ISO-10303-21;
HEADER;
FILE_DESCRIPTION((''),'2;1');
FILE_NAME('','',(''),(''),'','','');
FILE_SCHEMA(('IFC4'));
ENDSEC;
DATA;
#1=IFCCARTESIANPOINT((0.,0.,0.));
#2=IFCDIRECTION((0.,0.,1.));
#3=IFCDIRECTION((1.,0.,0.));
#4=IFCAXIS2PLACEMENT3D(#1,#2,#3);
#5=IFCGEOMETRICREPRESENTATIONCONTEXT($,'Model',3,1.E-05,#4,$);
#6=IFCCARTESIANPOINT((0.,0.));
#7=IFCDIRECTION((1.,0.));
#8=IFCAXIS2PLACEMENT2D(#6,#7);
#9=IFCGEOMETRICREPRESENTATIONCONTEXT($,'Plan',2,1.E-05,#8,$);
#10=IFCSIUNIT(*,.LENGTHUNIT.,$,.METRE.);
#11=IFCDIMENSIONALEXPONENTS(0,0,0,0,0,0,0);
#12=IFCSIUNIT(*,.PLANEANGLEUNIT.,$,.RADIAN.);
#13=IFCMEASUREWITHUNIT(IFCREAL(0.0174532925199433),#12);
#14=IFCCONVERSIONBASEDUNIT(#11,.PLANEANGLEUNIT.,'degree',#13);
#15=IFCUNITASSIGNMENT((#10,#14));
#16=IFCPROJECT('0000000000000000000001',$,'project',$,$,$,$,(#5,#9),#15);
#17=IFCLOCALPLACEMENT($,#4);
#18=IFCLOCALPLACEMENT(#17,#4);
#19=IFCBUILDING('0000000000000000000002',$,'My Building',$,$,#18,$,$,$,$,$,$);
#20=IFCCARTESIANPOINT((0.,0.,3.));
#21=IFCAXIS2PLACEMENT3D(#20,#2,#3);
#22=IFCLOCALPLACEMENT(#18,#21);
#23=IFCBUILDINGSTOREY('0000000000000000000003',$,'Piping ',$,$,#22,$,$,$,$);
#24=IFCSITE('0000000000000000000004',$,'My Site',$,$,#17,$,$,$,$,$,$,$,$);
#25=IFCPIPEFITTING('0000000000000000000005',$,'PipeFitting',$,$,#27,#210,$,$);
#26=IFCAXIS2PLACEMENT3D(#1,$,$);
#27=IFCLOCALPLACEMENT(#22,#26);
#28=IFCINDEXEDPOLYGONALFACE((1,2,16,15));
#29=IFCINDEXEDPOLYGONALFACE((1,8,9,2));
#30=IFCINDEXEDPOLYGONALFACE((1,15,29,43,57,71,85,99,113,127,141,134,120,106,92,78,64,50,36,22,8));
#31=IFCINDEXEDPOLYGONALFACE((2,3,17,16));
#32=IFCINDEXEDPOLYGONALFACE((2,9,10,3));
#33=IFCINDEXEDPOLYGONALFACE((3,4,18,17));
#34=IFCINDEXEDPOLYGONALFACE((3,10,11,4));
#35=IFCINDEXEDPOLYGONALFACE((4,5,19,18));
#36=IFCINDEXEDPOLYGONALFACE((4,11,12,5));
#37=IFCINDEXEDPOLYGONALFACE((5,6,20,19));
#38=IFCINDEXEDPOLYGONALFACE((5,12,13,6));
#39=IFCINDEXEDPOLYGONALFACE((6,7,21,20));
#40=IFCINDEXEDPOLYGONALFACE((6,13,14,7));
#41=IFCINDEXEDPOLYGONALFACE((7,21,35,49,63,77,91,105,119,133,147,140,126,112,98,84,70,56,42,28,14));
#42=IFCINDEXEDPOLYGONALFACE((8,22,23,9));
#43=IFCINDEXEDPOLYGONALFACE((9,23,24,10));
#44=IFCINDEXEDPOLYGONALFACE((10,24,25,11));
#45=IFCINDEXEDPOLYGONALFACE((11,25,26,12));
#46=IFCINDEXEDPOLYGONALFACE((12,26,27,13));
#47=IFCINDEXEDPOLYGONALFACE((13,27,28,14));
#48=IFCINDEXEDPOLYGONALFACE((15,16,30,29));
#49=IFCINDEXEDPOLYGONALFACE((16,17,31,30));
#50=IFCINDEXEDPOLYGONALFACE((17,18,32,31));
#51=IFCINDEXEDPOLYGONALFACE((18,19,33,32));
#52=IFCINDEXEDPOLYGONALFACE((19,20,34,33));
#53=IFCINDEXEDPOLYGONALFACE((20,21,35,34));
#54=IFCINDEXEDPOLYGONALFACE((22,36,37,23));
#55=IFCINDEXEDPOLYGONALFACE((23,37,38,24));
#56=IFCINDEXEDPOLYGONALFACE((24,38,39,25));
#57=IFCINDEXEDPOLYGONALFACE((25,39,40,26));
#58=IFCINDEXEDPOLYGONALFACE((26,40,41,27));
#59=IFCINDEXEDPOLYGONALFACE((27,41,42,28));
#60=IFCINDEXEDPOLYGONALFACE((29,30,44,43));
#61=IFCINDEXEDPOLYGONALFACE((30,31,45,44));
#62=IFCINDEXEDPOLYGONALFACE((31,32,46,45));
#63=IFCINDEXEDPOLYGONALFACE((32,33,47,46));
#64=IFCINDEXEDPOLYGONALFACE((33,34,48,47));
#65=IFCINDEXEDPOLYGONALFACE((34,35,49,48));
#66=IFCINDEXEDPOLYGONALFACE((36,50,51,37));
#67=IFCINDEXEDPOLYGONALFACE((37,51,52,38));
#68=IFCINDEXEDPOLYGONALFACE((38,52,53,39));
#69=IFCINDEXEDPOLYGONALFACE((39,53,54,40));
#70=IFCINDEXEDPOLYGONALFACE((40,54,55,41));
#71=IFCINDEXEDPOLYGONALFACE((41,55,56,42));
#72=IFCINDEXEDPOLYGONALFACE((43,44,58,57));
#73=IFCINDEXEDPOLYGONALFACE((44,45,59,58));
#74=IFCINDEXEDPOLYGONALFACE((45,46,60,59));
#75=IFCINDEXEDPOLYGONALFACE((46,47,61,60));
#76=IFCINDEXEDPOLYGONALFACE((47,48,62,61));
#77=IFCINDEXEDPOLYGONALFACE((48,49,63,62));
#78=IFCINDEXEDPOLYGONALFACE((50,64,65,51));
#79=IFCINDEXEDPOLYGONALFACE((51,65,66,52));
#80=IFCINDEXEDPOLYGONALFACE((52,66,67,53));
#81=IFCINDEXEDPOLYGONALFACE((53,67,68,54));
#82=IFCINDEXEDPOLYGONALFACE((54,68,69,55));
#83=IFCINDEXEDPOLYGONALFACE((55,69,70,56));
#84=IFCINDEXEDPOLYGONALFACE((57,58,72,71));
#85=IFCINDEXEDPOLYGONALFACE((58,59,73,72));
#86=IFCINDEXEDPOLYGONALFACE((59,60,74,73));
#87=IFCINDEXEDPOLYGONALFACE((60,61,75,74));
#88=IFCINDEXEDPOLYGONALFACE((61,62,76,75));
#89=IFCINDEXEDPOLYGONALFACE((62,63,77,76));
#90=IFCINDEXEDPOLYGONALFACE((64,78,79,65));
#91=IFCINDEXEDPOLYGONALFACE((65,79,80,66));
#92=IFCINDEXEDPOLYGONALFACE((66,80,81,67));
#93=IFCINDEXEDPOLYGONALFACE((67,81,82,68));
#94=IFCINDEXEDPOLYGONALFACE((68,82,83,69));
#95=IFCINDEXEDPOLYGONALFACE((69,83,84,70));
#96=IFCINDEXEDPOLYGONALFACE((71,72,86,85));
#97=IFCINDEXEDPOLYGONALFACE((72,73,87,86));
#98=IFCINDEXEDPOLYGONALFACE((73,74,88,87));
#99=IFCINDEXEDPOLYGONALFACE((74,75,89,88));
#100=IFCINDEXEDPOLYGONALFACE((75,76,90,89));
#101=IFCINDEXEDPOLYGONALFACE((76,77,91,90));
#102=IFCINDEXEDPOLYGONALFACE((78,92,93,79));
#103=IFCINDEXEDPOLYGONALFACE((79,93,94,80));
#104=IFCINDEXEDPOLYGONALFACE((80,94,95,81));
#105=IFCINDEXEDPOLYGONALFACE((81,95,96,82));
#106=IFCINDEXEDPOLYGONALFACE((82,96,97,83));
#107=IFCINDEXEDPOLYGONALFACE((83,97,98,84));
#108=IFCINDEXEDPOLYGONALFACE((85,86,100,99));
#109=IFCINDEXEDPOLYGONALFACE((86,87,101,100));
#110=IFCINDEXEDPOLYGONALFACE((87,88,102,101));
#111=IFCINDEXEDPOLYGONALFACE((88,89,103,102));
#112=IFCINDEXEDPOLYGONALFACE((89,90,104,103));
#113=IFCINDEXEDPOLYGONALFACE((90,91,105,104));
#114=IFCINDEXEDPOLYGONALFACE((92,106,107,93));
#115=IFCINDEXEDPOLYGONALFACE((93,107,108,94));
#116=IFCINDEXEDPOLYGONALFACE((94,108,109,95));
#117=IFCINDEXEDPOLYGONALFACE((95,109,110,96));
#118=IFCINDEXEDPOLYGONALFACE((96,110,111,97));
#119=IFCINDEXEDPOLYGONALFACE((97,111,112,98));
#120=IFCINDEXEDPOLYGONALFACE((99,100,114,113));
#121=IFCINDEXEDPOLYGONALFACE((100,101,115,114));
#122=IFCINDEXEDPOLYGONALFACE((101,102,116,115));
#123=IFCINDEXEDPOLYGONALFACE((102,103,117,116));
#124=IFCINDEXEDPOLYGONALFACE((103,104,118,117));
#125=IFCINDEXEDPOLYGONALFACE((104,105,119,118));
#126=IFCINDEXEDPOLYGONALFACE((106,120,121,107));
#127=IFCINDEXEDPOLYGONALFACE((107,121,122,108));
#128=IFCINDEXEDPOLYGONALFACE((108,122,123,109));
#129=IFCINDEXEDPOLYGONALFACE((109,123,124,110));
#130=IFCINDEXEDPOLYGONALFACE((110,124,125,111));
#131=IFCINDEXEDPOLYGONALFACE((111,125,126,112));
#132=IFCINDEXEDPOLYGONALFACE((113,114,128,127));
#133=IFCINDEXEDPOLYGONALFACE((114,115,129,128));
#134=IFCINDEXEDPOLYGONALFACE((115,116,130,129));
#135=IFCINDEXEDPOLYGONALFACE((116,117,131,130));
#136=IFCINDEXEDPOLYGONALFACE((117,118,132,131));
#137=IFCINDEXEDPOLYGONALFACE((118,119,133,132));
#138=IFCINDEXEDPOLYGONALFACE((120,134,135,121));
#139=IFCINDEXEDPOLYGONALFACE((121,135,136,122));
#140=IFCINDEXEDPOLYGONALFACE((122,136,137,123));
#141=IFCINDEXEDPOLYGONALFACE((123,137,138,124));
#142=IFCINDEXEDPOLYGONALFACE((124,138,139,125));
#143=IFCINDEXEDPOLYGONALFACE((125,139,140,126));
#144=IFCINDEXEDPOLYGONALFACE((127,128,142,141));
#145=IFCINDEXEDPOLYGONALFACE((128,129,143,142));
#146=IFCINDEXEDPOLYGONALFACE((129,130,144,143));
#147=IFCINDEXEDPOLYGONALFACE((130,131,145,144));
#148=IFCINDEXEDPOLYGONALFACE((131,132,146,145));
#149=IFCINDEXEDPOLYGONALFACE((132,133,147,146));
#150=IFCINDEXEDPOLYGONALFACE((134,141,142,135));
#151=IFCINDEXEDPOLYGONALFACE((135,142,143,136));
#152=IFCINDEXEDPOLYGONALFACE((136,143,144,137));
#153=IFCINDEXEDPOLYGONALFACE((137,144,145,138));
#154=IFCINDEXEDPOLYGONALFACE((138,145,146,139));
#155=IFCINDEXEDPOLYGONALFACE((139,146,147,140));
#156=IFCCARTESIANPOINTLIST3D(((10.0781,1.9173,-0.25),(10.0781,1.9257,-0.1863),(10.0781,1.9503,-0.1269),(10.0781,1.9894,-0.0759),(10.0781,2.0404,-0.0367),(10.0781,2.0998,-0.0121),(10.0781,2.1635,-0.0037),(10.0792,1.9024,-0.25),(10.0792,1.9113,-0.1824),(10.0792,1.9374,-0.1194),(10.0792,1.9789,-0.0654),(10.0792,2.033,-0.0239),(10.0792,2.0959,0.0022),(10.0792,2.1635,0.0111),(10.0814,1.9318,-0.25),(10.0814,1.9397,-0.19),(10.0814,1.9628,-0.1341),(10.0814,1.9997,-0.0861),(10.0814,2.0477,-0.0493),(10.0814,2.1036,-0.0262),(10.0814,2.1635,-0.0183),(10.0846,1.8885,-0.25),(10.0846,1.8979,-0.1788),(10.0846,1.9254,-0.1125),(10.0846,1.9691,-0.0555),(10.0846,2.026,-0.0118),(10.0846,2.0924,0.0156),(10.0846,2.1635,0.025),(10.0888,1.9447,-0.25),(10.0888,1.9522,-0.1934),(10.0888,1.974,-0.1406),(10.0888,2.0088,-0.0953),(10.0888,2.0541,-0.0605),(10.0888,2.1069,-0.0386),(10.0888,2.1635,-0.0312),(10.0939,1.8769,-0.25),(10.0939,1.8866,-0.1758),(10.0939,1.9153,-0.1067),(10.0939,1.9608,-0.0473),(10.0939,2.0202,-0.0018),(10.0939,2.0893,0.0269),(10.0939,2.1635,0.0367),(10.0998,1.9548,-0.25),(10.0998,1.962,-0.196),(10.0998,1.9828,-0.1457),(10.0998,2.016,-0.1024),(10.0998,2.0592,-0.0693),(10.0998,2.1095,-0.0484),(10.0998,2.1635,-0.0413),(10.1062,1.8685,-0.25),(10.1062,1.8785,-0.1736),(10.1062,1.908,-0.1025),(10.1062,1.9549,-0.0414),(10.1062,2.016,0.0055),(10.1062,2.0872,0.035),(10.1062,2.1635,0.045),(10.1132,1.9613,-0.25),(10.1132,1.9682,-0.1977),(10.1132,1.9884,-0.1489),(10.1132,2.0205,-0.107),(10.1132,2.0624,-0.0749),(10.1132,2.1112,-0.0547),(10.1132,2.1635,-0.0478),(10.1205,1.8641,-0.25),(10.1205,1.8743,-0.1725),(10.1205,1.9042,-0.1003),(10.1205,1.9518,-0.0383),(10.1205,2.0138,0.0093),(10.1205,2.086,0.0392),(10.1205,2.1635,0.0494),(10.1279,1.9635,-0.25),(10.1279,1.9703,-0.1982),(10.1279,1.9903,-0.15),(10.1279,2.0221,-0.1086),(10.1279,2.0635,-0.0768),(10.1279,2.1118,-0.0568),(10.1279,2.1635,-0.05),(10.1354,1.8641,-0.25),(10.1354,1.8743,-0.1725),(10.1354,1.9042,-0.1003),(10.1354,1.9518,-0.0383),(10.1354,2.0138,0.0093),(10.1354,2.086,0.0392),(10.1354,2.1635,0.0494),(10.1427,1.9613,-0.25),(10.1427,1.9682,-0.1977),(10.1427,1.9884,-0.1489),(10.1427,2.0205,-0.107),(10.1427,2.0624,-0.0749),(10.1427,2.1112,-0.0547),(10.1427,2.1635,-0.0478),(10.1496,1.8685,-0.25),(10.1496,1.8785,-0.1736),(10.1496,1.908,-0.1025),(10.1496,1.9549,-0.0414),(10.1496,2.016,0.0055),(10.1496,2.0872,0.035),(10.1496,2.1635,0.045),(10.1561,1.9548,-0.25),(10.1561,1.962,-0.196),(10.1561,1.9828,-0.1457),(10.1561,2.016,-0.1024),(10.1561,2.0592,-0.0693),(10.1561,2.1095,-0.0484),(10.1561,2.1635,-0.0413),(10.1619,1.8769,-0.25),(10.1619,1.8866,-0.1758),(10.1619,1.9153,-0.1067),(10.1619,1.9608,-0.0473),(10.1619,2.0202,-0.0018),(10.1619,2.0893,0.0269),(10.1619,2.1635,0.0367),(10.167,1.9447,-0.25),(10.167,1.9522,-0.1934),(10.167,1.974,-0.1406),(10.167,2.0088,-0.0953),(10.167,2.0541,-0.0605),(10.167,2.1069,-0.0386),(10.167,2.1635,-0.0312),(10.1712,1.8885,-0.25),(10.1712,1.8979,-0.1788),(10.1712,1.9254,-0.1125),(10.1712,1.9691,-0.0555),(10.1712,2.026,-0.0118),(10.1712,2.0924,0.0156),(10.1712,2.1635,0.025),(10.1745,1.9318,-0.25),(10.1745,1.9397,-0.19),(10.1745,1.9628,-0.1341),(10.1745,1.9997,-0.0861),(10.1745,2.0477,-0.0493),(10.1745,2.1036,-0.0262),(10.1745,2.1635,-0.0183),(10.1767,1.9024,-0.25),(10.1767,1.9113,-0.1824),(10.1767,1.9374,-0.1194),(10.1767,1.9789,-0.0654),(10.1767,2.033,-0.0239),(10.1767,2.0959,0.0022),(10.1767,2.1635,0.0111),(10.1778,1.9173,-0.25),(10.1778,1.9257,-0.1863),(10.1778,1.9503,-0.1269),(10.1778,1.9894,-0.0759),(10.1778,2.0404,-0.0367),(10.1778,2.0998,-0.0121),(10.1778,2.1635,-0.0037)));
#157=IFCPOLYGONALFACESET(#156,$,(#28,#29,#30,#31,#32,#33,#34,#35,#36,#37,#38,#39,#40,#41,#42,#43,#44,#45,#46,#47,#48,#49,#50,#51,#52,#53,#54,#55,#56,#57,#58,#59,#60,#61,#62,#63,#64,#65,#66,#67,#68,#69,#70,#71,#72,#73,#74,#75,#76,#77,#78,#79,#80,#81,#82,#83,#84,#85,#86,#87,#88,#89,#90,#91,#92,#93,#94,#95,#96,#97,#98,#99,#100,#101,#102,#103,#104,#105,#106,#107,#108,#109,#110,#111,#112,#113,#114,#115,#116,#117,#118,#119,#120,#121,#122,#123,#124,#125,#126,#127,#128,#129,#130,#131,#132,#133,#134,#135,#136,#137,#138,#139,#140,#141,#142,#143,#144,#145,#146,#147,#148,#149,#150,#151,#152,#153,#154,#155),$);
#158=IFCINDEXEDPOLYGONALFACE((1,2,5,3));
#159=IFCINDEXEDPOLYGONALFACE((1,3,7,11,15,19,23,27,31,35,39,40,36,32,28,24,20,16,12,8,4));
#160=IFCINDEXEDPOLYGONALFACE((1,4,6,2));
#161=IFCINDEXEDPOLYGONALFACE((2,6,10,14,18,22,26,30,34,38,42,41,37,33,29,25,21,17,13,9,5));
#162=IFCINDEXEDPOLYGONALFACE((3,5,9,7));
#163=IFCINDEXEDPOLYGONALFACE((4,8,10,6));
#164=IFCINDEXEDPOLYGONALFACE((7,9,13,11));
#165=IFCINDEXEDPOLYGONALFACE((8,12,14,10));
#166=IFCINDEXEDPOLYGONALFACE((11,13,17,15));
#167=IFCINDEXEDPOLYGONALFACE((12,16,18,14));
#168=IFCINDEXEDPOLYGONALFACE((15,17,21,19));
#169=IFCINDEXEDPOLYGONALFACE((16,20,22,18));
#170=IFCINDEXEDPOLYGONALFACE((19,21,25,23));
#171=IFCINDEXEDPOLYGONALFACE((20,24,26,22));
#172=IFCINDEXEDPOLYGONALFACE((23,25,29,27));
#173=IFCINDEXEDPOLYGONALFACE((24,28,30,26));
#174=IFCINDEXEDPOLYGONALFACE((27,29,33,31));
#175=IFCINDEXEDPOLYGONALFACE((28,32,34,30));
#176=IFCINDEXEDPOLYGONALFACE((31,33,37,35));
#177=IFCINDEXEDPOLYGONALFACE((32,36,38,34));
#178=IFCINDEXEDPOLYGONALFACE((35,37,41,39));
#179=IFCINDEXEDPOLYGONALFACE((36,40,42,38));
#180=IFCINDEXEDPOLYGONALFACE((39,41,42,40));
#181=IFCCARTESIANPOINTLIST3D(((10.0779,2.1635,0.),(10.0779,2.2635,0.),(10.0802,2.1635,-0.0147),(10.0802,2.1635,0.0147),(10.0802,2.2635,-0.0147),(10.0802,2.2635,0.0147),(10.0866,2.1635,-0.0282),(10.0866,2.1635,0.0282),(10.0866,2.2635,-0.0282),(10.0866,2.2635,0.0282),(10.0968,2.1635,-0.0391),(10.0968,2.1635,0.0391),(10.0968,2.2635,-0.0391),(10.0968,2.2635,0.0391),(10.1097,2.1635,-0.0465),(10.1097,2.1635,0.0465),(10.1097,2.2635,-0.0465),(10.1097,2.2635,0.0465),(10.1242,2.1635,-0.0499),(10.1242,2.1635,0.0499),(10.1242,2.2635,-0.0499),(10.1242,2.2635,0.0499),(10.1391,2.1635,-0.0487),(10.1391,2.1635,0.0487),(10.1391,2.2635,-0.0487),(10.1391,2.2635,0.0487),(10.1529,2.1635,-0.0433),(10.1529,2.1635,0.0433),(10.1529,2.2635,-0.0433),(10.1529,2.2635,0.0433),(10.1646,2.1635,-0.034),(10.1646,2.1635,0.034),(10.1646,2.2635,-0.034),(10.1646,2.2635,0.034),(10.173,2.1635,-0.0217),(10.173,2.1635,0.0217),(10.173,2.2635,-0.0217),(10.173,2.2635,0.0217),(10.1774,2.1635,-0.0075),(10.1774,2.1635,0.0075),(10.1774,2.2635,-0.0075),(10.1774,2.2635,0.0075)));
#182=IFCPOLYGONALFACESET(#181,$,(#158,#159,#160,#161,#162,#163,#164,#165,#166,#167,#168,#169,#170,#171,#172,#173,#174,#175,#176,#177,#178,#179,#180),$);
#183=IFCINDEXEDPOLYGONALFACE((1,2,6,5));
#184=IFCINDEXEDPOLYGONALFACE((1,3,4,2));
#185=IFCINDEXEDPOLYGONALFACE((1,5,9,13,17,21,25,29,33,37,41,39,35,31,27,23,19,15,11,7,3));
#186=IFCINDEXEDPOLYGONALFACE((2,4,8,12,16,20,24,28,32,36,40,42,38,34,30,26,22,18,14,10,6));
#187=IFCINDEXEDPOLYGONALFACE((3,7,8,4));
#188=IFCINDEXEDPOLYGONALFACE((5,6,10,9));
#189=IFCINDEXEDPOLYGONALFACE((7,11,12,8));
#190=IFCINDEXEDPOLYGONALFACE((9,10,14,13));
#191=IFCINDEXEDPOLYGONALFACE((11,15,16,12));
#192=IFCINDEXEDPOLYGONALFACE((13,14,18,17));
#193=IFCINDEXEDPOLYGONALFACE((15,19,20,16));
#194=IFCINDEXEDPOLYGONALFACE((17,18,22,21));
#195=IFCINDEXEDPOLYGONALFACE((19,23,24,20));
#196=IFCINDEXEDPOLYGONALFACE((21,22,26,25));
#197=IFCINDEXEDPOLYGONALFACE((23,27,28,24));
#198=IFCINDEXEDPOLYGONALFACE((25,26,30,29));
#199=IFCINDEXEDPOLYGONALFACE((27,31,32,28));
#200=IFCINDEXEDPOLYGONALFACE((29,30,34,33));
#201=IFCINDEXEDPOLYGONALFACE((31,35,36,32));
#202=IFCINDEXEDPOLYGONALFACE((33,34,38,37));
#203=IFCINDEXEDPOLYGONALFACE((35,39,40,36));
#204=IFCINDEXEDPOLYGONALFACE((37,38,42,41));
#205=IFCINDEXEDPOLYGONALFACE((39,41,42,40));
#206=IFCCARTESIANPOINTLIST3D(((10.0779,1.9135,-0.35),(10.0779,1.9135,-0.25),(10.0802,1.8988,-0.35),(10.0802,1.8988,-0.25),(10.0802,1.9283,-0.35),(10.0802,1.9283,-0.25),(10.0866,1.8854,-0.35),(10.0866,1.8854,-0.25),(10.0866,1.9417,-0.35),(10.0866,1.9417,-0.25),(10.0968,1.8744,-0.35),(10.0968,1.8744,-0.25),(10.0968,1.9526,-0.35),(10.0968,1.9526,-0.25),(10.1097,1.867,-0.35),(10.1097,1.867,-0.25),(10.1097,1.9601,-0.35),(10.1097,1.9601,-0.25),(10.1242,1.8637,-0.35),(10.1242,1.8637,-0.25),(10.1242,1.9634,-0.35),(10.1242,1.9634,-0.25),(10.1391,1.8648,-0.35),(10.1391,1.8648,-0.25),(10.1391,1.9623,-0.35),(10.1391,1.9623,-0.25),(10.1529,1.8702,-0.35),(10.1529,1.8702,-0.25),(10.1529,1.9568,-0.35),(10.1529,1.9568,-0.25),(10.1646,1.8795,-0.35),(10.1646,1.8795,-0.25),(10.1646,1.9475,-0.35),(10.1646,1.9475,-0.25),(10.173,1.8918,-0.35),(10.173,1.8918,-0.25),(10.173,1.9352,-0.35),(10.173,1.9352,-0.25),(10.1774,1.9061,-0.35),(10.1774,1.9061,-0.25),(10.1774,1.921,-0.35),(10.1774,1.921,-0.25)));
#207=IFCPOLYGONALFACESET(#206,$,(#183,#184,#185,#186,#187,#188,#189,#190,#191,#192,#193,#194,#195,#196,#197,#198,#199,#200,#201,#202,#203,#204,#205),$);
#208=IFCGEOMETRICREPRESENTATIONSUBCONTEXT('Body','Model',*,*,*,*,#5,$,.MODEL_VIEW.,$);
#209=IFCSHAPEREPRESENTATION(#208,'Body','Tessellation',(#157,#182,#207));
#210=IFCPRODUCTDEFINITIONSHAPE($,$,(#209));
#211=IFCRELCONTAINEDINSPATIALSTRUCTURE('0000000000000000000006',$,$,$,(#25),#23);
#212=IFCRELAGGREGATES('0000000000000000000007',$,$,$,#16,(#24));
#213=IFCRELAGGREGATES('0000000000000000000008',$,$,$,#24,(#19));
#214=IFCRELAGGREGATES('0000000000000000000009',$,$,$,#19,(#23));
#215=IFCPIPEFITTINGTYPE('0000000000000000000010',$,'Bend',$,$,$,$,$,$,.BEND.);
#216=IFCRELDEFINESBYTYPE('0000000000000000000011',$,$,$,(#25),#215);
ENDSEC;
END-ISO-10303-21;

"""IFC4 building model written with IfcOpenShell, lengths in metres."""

from ifc_helpers import new_model, entity, si_unit, converted_unit, frame, origin_with_axes, origin_2d_with_axis, place, context, subcontext, project, spatial, circle, extrude, source, transform, mapped, type_object, type_shapes, element, save


model = new_model("IFC4")

# Units and contexts
model_context = context("Model", 3, precision=1e-05, world=origin_with_axes())
plan_context = context("Plan", 2, precision=1e-05, world=origin_2d_with_axis())
body_context = subcontext(model_context, "Body", "Model", "MODEL_VIEW")
ifc_project = project(units=[si_unit("LENGTHUNIT", "METRE"), converted_unit("PLANEANGLEUNIT", "degree", entity("IfcReal", 0.0174532925199433), si_unit("PLANEANGLEUNIT", "RADIAN"), dimensions=[0, 0, 0, 0, 0, 0, 0])], contexts=[model_context, plan_context])

# Site, building, storey
site_placement = place(None, origin_with_axes())
site = spatial("IfcSite", under=ifc_project, at=site_placement, Name="My Site")
building_placement = place(site_placement, origin_with_axes())
building = spatial("IfcBuilding", under=site, at=building_placement, Name="My Building")
storey_placement = place(building_placement, frame((0.0, 0.0, 3.0), z_axis=(0.0, 0.0, 1.0), x_axis=(1.0, 0.0, 0.0)))
storey = spatial("IfcBuildingStorey", under=building, at=storey_placement, Name="Piping ")

# Pipe fitting
pipe_fitting_type = type_object("IfcPipeFittingType", Name="Bend", PredefinedType="BEND")
shared_shape = source(origin_with_axes(), body_context, "Body", "SolidModel", [
    entity("IfcSweptDiskSolid", entity("IfcIndexedPolyCurve", entity("IfcCartesianPointList3D", [[0.0, 0.0, -0.1], [0.0, -0.0732, -0.2768], [0.0, -0.25, -0.35]]), [entity("IfcArcIndex", [1, 2, 3])]), 0.05),
    extrude(circle(Radius=0.05), origin_with_axes(), (0.0, 0.0, -1.0), 0.1),
    extrude(circle(Radius=0.05), frame((0.0, -0.25, -0.35), z_axis=(0.0, -1.0, 0.0), x_axis=(1.0, 0.0, 0.0)), (0.0, 0.0, 1.0), 0.1),
])
type_shapes(pipe_fitting_type, [shared_shape])
for number, where, z_axis, x_axis, name in (
    (1, (10.1279, 2.2635, 0.0), (0.0, 1.0, 0.0), (-1.0, 0.0, 0.0), "PipeFitting"),
):
    element("IfcPipeFitting", number, at=place(storey_placement, frame(where, z_axis=z_axis, x_axis=x_axis)), inside=storey, type_object=pipe_fitting_type, Name=name, context=body_context, shape_type="MappedRepresentation", body=[
        mapped(shared_shape, transform((0.0, 0.0, 0.0), x_axis=(1.0, 0.0, 0.0), y_axis=(0.0, 1.0, 0.0), z_axis=(0.0, 0.0, 1.0), scale=1.0)),
    ])

save(model, "model.ifc")
